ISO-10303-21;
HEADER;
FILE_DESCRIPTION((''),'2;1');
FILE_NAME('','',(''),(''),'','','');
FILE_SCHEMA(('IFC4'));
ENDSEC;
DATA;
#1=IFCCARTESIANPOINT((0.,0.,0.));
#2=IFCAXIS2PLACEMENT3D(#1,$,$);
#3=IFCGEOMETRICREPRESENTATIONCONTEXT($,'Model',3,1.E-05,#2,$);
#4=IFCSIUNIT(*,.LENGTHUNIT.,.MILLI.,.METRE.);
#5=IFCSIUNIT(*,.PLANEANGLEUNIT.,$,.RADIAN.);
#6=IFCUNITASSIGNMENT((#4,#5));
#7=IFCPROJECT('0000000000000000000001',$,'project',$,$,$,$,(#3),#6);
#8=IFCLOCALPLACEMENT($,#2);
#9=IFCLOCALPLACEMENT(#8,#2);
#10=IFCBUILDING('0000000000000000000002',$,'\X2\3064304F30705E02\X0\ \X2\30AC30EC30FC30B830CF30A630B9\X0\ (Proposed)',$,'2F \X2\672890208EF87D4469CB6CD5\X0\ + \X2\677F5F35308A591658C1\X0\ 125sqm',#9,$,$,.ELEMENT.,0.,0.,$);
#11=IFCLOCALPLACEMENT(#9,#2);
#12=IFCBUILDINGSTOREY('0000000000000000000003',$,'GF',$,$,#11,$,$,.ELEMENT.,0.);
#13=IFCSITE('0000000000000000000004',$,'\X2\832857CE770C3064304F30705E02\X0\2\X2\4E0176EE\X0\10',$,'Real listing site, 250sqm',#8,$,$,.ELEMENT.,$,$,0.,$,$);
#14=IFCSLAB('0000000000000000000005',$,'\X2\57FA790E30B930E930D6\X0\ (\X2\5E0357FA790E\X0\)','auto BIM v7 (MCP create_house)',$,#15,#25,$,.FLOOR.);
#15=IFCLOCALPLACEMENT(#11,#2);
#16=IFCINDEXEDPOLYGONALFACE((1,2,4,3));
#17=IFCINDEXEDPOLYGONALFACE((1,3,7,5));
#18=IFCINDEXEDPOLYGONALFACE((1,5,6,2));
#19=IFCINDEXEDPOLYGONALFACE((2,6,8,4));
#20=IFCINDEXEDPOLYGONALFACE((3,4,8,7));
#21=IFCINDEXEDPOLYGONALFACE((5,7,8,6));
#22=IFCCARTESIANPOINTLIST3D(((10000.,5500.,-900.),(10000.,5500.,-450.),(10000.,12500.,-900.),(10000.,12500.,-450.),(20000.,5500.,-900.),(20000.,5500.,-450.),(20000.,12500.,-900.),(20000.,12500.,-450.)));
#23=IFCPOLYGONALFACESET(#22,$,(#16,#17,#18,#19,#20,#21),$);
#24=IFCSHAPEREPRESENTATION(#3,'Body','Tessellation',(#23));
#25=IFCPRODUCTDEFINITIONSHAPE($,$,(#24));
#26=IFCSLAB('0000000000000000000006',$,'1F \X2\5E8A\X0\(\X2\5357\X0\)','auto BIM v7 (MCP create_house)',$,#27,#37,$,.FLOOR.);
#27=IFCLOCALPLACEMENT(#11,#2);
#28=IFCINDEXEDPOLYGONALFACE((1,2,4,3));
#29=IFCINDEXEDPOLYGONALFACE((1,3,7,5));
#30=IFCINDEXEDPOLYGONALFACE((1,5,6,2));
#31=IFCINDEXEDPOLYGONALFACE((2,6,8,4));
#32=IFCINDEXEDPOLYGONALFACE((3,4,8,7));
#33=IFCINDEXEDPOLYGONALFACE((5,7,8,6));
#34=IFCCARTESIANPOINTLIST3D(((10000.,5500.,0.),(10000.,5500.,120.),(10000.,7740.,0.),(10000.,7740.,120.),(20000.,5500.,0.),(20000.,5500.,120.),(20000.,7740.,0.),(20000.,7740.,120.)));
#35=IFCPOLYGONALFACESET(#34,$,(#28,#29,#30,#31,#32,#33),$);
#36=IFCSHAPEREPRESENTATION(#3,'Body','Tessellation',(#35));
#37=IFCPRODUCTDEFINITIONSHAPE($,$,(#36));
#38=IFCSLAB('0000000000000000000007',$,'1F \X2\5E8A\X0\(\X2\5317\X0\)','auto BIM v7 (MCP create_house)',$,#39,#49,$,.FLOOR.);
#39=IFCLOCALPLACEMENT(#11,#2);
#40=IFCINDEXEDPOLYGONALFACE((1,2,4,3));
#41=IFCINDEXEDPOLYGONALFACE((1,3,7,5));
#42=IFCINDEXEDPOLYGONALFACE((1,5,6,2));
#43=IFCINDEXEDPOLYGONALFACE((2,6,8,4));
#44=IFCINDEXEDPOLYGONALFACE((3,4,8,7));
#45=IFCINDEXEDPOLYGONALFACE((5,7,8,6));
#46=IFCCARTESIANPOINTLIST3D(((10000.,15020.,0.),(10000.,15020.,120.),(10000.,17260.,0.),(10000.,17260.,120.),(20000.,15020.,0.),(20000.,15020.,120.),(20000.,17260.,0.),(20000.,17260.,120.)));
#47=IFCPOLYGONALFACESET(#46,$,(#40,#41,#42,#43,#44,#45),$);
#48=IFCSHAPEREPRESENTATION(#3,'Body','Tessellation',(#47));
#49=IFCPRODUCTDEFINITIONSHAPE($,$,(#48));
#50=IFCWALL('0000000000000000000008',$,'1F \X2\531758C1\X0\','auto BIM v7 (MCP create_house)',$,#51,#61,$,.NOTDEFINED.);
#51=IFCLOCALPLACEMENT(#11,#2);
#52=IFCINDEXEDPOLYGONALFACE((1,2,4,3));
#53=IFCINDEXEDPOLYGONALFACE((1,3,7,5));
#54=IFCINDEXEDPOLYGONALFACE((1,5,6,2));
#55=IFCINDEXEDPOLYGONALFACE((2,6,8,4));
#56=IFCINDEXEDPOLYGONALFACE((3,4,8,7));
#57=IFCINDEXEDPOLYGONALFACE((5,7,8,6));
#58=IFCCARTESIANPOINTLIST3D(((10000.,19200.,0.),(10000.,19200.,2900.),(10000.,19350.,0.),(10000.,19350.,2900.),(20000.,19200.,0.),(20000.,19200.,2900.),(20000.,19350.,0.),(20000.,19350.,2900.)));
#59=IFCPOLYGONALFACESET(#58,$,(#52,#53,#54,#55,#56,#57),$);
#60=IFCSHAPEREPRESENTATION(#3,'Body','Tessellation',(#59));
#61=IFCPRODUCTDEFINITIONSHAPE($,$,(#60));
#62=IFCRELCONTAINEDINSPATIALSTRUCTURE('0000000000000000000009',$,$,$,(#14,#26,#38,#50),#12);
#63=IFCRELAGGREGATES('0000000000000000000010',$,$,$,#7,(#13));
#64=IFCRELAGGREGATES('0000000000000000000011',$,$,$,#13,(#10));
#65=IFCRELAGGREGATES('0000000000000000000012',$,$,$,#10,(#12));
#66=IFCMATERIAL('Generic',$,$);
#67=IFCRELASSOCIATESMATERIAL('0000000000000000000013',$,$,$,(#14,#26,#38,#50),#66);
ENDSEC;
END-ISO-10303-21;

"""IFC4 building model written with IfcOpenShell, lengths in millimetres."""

from ifc_helpers import new_model, si_unit, frame, frame_2d, origin, place, context, project, spatial, rectangle, extrude, material, element, save


model = new_model("IFC4")

# Units and contexts
model_context = context("Model", 3, precision=1e-05, world=origin())
ifc_project = project(units=[si_unit("LENGTHUNIT", "METRE", prefix="MILLI"), si_unit("PLANEANGLEUNIT", "RADIAN")], contexts=[model_context])

# Site, building, storey
site_placement = place(None, origin())
site = spatial("IfcSite", under=ifc_project, at=site_placement, Name="茨城県つくば市2丁目10", ObjectType="Real listing site, 250sqm", CompositionType="ELEMENT", RefElevation=0.0)
building_placement = place(site_placement, origin())
building = spatial("IfcBuilding", under=site, at=building_placement, Name="つくば市 ガレージハウス (Proposed)", ObjectType="2F 木造軸組構法 + 板張り外壁 125sqm", CompositionType="ELEMENT", ElevationOfRefHeight=0.0, ElevationOfTerrain=0.0)
storey_placement = place(building_placement, origin())
storey = spatial("IfcBuildingStorey", under=building, at=storey_placement, Name="GF", CompositionType="ELEMENT", Elevation=0.0)

# Slabs
ifc_material = material(Name="Generic")
slab_1_placement = place(storey_placement, frame((5000.0, 2750.0, -450.0)))
element("IfcSlab", 1, at=slab_1_placement, inside=storey, material=ifc_material, Name="基礎スラブ (布基礎)", Description="auto BIM v7 (MCP create_house)", PredefinedType="FLOOR", context=model_context, shape_type="SweptSolid", body=[
    extrude(rectangle(XDim=10000.0, YDim=7000.0, at=frame_2d((5000.0, 3500.0))), frame((5000.0, 2750.0, -450.0)), (0.0, 0.0, 1.0), 450.0),
])
slab_2_placement = place(storey_placement, frame((5000.0, 2750.0, 0.0)))
element("IfcSlab", 2, at=slab_2_placement, inside=storey, material=ifc_material, Name="1F 床(南)", Description="auto BIM v7 (MCP create_house)", PredefinedType="FLOOR", context=model_context, shape_type="SweptSolid", body=[
    extrude(rectangle(XDim=10000.0, YDim=2240.0, at=frame_2d((5000.0, 1120.0))), frame((5000.0, 2750.0, 0.0)), (0.0, 0.0, 1.0), 120.0),
])
slab_3_placement = place(storey_placement, frame((5000.0, 7510.0, 0.0)))
element("IfcSlab", 3, at=slab_3_placement, inside=storey, material=ifc_material, Name="1F 床(北)", Description="auto BIM v7 (MCP create_house)", PredefinedType="FLOOR", context=model_context, shape_type="SweptSolid", body=[
    extrude(rectangle(XDim=10000.0, YDim=2240.0, at=frame_2d((5000.0, 1120.0))), frame((5000.0, 7510.0, 0.0)), (0.0, 0.0, 1.0), 120.0),
])

# Wall
wall_1_placement = place(storey_placement, frame((5000.0, 9600.0, 0.0)))
element("IfcWall", 4, at=wall_1_placement, inside=storey, material=ifc_material, Name="1F 北壁", Description="auto BIM v7 (MCP create_house)", PredefinedType="NOTDEFINED", context=model_context, shape_type="SweptSolid", body=[
    extrude(rectangle(XDim=10000.0, YDim=150.0, at=frame_2d((5000.0, 75.0))), frame((5000.0, 9600.0, 0.0)), (0.0, 0.0, 1.0), 2900.0),
])

save(model, "model.ifc")
